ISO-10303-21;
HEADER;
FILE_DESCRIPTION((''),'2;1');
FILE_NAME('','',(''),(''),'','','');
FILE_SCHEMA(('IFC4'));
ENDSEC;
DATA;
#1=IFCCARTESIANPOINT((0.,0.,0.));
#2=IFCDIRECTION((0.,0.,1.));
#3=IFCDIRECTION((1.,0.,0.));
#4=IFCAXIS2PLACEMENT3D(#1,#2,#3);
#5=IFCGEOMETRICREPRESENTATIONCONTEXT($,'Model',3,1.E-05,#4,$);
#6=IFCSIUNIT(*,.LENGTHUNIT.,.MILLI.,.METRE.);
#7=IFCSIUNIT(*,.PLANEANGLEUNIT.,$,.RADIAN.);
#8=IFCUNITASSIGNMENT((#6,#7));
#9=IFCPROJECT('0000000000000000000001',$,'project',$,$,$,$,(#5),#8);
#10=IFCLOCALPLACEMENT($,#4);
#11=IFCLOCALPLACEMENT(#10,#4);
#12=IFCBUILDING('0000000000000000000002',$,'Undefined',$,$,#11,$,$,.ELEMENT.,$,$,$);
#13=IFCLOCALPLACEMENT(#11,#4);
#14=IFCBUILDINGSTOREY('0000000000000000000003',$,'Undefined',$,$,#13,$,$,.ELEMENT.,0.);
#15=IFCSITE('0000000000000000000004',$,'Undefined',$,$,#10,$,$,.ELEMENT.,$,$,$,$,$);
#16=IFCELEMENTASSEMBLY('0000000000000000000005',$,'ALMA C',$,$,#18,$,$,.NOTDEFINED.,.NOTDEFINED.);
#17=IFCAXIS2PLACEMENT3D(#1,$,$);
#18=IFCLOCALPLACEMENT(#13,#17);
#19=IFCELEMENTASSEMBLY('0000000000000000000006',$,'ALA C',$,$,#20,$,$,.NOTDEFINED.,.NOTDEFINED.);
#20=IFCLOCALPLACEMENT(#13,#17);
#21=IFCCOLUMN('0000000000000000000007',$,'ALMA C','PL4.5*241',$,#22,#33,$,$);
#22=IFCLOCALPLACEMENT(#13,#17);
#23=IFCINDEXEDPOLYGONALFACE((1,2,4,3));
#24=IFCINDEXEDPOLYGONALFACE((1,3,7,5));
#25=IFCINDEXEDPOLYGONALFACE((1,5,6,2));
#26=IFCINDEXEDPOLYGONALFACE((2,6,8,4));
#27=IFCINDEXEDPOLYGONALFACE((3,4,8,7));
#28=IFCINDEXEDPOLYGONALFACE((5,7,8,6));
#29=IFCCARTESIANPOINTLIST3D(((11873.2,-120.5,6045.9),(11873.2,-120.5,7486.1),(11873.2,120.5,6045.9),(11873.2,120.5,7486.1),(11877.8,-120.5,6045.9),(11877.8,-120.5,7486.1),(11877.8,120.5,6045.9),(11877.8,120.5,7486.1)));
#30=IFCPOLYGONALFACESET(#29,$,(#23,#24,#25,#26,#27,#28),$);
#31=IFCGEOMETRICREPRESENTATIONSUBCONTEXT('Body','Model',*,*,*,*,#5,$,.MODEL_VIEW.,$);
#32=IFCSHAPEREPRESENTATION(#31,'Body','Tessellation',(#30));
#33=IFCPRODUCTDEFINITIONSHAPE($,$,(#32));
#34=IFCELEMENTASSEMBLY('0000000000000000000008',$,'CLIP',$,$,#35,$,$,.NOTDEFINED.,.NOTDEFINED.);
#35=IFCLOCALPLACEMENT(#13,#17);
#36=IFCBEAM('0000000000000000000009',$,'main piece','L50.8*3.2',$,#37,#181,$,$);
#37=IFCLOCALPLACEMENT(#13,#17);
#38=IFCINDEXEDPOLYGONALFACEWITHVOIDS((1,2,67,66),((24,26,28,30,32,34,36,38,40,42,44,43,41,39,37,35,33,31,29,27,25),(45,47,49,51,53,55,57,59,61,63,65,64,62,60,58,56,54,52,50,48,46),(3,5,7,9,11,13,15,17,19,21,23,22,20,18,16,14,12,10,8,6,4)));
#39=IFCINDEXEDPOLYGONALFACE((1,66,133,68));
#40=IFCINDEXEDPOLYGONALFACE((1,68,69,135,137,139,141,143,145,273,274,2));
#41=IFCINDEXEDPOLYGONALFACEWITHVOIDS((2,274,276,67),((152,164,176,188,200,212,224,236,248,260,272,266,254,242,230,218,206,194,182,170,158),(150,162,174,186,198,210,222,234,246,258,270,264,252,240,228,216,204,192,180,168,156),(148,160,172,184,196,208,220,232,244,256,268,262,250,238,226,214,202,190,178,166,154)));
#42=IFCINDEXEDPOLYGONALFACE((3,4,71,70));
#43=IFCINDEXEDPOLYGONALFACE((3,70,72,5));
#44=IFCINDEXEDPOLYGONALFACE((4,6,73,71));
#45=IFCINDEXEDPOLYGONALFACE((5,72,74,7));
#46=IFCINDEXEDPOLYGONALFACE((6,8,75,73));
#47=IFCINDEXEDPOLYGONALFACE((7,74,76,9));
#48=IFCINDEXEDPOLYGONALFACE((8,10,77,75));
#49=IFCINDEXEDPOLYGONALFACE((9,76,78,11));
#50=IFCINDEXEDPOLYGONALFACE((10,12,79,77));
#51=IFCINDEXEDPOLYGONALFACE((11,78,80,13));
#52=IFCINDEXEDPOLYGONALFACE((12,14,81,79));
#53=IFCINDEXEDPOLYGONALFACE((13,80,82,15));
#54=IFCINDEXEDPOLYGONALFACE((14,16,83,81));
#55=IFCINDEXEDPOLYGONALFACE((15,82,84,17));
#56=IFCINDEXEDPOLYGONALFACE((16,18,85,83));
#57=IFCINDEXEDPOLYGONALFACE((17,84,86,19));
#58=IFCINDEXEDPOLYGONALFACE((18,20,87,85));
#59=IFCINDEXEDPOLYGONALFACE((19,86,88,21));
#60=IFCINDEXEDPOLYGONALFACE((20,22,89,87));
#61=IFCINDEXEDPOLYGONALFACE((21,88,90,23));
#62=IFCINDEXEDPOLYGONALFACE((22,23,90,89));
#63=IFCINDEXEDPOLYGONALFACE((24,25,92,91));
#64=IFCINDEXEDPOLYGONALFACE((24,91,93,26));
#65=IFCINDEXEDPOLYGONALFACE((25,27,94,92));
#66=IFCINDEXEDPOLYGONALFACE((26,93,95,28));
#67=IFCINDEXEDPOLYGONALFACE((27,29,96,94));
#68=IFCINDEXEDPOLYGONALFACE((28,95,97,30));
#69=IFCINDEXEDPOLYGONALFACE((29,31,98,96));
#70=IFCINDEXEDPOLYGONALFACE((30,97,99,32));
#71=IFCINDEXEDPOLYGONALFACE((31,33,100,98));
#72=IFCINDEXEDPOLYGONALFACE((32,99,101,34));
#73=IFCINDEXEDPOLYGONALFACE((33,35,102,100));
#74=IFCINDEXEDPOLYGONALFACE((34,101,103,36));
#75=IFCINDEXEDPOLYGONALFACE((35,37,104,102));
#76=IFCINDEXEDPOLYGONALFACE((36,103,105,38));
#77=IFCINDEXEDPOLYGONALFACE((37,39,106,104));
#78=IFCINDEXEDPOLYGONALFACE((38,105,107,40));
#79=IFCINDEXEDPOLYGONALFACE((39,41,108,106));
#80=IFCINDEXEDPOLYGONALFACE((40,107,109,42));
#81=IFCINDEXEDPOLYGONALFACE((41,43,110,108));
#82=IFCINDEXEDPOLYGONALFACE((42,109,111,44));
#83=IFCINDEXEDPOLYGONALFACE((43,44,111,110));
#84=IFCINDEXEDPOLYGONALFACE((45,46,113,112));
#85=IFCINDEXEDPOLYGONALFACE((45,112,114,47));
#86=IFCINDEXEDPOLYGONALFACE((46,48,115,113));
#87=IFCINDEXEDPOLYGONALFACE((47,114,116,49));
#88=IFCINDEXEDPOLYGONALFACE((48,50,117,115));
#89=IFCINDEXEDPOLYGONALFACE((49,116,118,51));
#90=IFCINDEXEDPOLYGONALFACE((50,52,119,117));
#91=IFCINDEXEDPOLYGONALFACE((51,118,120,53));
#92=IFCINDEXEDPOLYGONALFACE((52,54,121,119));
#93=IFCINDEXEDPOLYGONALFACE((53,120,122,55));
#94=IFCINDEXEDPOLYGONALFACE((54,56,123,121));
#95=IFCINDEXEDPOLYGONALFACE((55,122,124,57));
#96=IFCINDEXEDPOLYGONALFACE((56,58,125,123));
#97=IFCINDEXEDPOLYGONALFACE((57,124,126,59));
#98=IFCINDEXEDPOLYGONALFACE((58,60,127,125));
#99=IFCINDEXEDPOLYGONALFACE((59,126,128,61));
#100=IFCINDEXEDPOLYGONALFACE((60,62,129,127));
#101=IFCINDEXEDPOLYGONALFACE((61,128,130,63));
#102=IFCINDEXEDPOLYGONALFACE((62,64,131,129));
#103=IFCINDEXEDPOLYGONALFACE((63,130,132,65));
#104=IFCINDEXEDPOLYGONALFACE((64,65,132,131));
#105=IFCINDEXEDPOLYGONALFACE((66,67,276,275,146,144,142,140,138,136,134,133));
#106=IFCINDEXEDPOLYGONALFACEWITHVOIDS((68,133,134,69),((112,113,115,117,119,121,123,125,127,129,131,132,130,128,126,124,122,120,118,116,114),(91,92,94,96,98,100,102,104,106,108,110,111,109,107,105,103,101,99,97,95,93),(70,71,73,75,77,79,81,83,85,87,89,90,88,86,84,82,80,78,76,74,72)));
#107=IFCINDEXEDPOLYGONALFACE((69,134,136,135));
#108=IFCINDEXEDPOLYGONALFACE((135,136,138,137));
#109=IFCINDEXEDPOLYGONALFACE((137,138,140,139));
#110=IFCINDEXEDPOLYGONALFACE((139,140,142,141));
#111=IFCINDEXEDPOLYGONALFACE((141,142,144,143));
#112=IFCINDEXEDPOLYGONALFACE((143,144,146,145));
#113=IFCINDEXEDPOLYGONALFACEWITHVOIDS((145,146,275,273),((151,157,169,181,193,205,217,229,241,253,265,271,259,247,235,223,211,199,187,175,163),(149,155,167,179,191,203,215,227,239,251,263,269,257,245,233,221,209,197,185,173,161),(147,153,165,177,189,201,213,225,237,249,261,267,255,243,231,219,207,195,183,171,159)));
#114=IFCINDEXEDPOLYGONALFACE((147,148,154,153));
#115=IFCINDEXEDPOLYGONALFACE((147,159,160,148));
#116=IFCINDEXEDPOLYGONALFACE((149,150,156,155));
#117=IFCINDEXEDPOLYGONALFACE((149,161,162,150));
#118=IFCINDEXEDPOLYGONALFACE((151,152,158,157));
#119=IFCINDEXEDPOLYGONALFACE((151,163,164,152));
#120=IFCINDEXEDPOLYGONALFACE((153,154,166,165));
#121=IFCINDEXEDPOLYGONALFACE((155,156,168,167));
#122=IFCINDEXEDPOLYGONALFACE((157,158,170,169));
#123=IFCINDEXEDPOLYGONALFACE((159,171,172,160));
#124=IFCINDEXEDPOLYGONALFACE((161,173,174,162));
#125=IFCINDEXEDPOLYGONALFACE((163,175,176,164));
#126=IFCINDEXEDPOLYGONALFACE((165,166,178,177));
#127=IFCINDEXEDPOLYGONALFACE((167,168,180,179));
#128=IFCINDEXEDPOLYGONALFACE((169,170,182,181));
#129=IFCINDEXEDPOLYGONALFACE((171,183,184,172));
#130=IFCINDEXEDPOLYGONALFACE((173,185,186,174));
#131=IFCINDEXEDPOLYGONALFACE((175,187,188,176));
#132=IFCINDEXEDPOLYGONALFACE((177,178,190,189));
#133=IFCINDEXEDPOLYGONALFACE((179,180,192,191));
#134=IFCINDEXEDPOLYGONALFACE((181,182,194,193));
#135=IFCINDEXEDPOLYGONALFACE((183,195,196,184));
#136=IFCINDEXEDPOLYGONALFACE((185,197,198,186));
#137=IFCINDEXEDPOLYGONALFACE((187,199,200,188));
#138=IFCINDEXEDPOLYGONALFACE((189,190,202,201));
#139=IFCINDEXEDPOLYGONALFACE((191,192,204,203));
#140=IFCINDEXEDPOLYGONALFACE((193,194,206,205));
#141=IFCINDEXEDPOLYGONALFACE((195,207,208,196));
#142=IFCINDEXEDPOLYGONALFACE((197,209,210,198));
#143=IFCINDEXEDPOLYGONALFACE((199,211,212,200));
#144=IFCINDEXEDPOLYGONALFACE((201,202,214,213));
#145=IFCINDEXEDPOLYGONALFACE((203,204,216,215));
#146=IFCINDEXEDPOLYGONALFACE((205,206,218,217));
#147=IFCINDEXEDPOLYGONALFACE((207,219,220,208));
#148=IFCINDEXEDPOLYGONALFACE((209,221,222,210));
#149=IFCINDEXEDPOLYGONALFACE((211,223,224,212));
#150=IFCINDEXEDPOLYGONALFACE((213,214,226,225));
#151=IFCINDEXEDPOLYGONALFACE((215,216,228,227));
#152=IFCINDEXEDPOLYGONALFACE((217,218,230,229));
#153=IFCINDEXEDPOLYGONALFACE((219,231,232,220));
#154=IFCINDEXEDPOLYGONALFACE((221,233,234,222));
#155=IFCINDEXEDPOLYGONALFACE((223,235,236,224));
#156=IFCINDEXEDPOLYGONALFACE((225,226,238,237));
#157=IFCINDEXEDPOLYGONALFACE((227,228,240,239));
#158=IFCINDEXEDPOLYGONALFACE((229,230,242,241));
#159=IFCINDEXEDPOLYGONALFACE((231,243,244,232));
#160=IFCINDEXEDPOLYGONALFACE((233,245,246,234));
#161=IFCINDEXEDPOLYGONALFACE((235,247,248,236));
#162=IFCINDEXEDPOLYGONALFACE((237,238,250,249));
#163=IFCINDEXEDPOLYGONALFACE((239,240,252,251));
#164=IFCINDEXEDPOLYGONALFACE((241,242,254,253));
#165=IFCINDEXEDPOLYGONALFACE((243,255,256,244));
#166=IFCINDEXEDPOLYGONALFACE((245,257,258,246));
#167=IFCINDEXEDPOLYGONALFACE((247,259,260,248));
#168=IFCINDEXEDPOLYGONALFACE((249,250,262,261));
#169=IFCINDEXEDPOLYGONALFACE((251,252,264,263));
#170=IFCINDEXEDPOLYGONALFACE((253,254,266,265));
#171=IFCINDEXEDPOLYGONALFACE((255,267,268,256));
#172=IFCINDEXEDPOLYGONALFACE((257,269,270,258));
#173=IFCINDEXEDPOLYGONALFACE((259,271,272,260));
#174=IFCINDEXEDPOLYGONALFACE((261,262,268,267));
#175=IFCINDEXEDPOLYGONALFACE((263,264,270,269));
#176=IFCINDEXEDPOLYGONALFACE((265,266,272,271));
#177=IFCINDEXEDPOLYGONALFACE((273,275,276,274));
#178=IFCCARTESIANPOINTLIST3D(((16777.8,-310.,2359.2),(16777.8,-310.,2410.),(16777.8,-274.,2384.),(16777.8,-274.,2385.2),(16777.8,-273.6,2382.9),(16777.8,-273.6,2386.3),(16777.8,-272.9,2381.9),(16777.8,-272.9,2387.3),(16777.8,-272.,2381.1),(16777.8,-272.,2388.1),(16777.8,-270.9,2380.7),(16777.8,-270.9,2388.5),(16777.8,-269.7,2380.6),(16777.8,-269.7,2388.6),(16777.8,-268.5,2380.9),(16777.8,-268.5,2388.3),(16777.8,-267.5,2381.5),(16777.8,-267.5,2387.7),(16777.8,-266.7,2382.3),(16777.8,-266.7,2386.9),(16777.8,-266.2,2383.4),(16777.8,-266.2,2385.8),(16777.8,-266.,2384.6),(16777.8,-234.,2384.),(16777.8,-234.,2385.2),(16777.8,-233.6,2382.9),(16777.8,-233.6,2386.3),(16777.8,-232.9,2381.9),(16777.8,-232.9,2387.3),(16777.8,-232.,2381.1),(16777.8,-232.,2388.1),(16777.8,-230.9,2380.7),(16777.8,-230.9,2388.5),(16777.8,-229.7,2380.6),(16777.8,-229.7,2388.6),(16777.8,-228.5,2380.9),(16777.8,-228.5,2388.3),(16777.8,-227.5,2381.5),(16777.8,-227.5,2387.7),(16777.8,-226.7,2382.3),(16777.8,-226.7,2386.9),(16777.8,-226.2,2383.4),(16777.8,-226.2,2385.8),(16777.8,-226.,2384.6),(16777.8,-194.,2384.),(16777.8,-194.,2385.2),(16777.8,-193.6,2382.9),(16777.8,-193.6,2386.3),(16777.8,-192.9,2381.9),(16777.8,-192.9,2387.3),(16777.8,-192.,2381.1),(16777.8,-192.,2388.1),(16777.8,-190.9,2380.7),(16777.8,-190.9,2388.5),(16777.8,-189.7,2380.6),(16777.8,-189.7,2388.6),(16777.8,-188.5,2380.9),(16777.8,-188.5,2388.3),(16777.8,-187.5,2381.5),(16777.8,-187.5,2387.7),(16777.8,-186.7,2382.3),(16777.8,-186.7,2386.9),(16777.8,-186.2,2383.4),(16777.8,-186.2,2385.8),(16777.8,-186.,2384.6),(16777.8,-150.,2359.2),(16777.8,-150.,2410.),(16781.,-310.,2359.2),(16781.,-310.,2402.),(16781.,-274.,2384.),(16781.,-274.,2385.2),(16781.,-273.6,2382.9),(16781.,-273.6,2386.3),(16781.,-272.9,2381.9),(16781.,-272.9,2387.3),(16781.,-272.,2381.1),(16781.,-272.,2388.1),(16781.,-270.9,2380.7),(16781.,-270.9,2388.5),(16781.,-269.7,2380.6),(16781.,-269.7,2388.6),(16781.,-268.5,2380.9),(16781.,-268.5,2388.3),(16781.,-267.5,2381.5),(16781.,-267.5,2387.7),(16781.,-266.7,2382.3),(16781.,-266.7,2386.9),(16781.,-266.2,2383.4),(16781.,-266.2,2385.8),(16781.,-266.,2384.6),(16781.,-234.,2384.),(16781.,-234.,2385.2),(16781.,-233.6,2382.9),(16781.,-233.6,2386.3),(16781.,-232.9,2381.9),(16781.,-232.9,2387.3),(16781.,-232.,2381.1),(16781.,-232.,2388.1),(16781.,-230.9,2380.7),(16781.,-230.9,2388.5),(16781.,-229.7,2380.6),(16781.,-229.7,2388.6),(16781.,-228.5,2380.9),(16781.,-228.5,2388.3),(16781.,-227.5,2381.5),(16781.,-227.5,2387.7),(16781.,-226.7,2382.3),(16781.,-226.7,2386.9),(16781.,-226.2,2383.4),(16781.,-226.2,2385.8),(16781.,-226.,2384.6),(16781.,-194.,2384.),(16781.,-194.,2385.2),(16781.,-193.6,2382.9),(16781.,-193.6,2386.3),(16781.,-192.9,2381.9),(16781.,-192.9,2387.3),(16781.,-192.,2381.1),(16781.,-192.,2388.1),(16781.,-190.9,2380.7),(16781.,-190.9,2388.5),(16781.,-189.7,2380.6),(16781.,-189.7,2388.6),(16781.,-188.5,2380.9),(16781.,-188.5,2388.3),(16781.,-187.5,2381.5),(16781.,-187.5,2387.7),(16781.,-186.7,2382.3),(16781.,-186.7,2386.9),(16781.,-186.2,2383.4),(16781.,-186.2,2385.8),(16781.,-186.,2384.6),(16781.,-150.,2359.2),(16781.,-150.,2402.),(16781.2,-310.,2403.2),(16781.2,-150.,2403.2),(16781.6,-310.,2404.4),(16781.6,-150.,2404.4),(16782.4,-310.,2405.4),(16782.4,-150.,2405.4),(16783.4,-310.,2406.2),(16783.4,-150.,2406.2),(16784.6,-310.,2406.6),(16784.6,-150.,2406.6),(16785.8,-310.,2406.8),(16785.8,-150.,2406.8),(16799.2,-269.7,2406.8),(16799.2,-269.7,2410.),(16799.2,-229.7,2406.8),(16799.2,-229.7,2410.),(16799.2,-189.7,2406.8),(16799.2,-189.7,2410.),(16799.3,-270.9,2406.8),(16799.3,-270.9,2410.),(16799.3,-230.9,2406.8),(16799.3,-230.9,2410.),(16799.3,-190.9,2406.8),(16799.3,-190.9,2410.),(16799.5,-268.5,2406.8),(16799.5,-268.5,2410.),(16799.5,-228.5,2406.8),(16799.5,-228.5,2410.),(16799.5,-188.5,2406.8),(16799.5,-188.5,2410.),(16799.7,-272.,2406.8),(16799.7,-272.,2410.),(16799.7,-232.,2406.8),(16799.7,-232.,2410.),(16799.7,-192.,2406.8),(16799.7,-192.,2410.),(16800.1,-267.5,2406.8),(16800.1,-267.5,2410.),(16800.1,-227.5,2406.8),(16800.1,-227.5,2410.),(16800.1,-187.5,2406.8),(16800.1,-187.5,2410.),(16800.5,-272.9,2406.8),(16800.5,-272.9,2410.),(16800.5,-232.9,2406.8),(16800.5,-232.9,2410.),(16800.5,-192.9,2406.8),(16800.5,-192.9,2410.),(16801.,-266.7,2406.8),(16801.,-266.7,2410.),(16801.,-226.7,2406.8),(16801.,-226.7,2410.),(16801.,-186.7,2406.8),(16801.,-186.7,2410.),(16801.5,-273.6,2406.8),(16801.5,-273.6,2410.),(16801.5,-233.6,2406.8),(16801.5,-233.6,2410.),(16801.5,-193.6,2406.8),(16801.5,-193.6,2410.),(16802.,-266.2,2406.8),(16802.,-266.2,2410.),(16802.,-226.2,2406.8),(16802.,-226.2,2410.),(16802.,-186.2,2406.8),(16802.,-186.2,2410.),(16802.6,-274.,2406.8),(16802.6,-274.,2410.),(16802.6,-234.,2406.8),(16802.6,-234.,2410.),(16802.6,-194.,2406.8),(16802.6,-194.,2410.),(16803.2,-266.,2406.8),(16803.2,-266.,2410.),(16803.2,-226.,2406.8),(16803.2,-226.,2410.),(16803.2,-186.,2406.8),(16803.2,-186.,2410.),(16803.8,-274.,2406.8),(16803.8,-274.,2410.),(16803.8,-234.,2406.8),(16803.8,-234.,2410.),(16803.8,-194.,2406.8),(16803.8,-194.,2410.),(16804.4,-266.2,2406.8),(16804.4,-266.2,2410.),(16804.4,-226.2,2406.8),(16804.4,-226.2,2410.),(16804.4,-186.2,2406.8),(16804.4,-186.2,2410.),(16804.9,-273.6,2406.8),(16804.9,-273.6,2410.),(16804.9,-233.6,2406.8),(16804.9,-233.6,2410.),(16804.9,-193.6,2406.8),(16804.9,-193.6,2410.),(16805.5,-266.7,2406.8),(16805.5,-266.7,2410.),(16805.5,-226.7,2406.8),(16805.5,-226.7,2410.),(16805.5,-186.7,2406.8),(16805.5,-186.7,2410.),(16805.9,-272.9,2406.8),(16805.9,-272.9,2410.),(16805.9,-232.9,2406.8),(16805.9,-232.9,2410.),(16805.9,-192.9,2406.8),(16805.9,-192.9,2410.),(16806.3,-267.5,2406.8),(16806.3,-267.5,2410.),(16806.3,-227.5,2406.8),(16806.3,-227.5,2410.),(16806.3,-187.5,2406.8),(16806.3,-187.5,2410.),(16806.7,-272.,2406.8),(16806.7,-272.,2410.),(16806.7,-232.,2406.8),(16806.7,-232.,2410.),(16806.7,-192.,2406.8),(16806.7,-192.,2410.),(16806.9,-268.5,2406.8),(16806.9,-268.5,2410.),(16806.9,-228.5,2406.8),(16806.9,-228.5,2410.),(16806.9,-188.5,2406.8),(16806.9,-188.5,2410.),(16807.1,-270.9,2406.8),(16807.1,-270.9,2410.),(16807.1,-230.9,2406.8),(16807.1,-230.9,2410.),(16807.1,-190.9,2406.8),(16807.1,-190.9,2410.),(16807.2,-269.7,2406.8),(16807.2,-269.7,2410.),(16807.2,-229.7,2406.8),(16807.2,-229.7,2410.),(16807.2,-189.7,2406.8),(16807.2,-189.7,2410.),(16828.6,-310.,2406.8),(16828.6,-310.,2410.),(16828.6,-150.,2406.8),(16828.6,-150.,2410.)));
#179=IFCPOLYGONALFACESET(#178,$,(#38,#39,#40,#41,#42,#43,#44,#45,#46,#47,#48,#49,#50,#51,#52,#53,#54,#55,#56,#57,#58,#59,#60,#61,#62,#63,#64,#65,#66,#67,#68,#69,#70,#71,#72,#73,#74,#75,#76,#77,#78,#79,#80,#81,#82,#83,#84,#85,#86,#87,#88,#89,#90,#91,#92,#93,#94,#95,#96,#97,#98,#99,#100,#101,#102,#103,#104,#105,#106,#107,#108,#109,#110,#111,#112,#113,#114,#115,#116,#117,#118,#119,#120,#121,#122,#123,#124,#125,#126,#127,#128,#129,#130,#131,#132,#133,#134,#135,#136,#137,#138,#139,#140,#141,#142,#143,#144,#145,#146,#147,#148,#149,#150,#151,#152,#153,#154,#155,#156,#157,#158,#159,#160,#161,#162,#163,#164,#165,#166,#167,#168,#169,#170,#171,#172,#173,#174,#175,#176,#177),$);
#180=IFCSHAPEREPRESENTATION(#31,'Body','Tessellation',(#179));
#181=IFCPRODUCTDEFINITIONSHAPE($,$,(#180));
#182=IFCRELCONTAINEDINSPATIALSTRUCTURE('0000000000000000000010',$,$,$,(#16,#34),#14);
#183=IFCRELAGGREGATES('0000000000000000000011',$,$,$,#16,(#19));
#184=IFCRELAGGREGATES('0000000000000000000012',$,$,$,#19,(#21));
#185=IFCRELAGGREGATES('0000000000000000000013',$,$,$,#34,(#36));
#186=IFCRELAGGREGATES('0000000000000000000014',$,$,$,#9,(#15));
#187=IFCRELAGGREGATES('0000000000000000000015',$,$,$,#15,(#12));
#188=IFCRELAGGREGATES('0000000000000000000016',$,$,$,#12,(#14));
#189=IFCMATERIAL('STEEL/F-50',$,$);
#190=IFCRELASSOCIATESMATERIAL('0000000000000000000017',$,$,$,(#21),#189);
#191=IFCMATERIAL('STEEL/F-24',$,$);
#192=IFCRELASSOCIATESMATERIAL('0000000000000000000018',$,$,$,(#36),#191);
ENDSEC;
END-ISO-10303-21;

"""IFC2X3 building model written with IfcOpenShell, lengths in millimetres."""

from ifc_helpers import new_model, si_unit, frame, origin_with_axes, origin_2d_with_axis, place, context, subcontext, project, spatial, rectangle, circle, l_section, extrude, source, transform, mapped, material, element, aggregate, save


model = new_model("IFC2X3")

# Units and contexts
model_context = context("Model", 3, precision=1e-05, world=origin_with_axes())
body_context = subcontext(model_context, "Body", "Model", "MODEL_VIEW")
ifc_project = project(units=[si_unit("LENGTHUNIT", "METRE", prefix="MILLI"), si_unit("PLANEANGLEUNIT", "RADIAN")], contexts=[model_context])

# Site, building, storey
site_placement = place(None, origin_with_axes())
site = spatial("IfcSite", under=ifc_project, at=site_placement, Name="Undefined", CompositionType="ELEMENT")
building_placement = place(site_placement, origin_with_axes())
building = spatial("IfcBuilding", under=site, at=building_placement, Name="Undefined", CompositionType="ELEMENT")
storey_placement = place(building_placement, origin_with_axes())
storey = spatial("IfcBuildingStorey", under=building, at=storey_placement, Name="Undefined", CompositionType="ELEMENT", Elevation=0.0)

# Element assemblies, column
assembly_1_placement = place(storey_placement, origin_with_axes())
assembly_1 = element("IfcElementAssembly", 1, at=assembly_1_placement, inside=storey, Name="ALMA C", AssemblyPlace="NOTDEFINED", PredefinedType="NOTDEFINED")
assembly_2_placement = place(assembly_1_placement, origin_with_axes())
assembly_2 = element("IfcElementAssembly", 2, at=assembly_2_placement, Name="ALA C", AssemblyPlace="NOTDEFINED", PredefinedType="NOTDEFINED")
aggregate(assembly_1, [assembly_2])
ifc_material_1 = material(Name="STEEL/F-50")
column_placement = place(assembly_2_placement, frame((11875.5, 0.0, 6045.9), z_axis=(0.0, 0.0, 1.0), x_axis=(0.0, -1.0, 0.0)))
column = element("IfcColumn", 3, at=column_placement, material=ifc_material_1, Name="ALMA C", Description="PL4.5*241", context=body_context, shape_type="SweptSolid", body=[
    extrude(rectangle(XDim=4.5, YDim=241.0, at=origin_2d_with_axis()), frame((0.0, 0.0, 1440.2), z_axis=(0.0, 0.0, -1.0), x_axis=(0.0, 1.0, 0.0)), (0.0, 0.0, 1.0), 1440.2),
])
aggregate(assembly_2, [column])

# Element assembly, beam, openings
assembly_3_placement = place(storey_placement, origin_with_axes())
assembly_3 = element("IfcElementAssembly", 4, at=assembly_3_placement, inside=storey, Name="CLIP", AssemblyPlace="NOTDEFINED", PredefinedType="NOTDEFINED")
ifc_material_2 = material(Name="STEEL/F-24")
beam_1_placement = place(assembly_3_placement, frame((16803.2, -150.0, 2384.6), z_axis=(0.0, 0.0, -1.0), x_axis=(0.0, -1.0, 0.0)))
beam_1 = element("IfcBeam", 5, at=beam_1_placement, material=ifc_material_2, Name="main piece", Description="L50.8*3.2", context=body_context, shape_type="SweptSolid", body=[
    extrude(l_section(Depth=50.8, Width=50.8, Thickness=3.2, FilletRadius=4.8, at=origin_2d_with_axis()), frame((160.0, 0.0, 0.0), z_axis=(-1.0, 0.0, 0.0), x_axis=(0.0, -1.0, 0.0)), (0.0, 0.0, 1.0), 160.0),
])
shared_shape_1 = source(origin_with_axes(), body_context, "Body", "SweptSolid", [
    extrude(circle(Radius=4.0, at=origin_2d_with_axis()), frame((0.0, -0.1, 0.0), z_axis=(0.0, 1.0, 0.0), x_axis=(1.0, 0.0, 0.0)), (0.0, 0.0, 1.0), 3.4),
])
opening_1_placement = place(assembly_3_placement, frame((16777.8, -270.0, 2384.6), z_axis=(0.0, 0.0, -1.0), x_axis=(0.0, 1.0, 0.0)))
element("IfcOpeningElement", 6, at=opening_1_placement, cuts=beam_1, ObjectType="Opening", context=body_context, shape_type="MappedRepresentation", body=[
    mapped(shared_shape_1, transform((0.0, 0.0, 0.0))),
    mapped(shared_shape_1, transform((40.0, 0.0, 0.0))),
    mapped(shared_shape_1, transform((80.0, 0.0, 0.0))),
])
opening_2_placement = place(assembly_3_placement, frame((16803.2, -270.0, 2410.0), z_axis=(-1.0, 0.0, 0.0), x_axis=(0.0, 1.0, 0.0)))
element("IfcOpeningElement", 7, at=opening_2_placement, cuts=beam_1, ObjectType="Opening", context=body_context, shape_type="MappedRepresentation", body=[
    mapped(shared_shape_1, transform((0.0, 0.0, 0.0))),
    mapped(shared_shape_1, transform((40.0, 0.0, 0.0))),
    mapped(shared_shape_1, transform((80.0, 0.0, 0.0))),
])
aggregate(assembly_3, [beam_1])

save(model, "model.ifc")
